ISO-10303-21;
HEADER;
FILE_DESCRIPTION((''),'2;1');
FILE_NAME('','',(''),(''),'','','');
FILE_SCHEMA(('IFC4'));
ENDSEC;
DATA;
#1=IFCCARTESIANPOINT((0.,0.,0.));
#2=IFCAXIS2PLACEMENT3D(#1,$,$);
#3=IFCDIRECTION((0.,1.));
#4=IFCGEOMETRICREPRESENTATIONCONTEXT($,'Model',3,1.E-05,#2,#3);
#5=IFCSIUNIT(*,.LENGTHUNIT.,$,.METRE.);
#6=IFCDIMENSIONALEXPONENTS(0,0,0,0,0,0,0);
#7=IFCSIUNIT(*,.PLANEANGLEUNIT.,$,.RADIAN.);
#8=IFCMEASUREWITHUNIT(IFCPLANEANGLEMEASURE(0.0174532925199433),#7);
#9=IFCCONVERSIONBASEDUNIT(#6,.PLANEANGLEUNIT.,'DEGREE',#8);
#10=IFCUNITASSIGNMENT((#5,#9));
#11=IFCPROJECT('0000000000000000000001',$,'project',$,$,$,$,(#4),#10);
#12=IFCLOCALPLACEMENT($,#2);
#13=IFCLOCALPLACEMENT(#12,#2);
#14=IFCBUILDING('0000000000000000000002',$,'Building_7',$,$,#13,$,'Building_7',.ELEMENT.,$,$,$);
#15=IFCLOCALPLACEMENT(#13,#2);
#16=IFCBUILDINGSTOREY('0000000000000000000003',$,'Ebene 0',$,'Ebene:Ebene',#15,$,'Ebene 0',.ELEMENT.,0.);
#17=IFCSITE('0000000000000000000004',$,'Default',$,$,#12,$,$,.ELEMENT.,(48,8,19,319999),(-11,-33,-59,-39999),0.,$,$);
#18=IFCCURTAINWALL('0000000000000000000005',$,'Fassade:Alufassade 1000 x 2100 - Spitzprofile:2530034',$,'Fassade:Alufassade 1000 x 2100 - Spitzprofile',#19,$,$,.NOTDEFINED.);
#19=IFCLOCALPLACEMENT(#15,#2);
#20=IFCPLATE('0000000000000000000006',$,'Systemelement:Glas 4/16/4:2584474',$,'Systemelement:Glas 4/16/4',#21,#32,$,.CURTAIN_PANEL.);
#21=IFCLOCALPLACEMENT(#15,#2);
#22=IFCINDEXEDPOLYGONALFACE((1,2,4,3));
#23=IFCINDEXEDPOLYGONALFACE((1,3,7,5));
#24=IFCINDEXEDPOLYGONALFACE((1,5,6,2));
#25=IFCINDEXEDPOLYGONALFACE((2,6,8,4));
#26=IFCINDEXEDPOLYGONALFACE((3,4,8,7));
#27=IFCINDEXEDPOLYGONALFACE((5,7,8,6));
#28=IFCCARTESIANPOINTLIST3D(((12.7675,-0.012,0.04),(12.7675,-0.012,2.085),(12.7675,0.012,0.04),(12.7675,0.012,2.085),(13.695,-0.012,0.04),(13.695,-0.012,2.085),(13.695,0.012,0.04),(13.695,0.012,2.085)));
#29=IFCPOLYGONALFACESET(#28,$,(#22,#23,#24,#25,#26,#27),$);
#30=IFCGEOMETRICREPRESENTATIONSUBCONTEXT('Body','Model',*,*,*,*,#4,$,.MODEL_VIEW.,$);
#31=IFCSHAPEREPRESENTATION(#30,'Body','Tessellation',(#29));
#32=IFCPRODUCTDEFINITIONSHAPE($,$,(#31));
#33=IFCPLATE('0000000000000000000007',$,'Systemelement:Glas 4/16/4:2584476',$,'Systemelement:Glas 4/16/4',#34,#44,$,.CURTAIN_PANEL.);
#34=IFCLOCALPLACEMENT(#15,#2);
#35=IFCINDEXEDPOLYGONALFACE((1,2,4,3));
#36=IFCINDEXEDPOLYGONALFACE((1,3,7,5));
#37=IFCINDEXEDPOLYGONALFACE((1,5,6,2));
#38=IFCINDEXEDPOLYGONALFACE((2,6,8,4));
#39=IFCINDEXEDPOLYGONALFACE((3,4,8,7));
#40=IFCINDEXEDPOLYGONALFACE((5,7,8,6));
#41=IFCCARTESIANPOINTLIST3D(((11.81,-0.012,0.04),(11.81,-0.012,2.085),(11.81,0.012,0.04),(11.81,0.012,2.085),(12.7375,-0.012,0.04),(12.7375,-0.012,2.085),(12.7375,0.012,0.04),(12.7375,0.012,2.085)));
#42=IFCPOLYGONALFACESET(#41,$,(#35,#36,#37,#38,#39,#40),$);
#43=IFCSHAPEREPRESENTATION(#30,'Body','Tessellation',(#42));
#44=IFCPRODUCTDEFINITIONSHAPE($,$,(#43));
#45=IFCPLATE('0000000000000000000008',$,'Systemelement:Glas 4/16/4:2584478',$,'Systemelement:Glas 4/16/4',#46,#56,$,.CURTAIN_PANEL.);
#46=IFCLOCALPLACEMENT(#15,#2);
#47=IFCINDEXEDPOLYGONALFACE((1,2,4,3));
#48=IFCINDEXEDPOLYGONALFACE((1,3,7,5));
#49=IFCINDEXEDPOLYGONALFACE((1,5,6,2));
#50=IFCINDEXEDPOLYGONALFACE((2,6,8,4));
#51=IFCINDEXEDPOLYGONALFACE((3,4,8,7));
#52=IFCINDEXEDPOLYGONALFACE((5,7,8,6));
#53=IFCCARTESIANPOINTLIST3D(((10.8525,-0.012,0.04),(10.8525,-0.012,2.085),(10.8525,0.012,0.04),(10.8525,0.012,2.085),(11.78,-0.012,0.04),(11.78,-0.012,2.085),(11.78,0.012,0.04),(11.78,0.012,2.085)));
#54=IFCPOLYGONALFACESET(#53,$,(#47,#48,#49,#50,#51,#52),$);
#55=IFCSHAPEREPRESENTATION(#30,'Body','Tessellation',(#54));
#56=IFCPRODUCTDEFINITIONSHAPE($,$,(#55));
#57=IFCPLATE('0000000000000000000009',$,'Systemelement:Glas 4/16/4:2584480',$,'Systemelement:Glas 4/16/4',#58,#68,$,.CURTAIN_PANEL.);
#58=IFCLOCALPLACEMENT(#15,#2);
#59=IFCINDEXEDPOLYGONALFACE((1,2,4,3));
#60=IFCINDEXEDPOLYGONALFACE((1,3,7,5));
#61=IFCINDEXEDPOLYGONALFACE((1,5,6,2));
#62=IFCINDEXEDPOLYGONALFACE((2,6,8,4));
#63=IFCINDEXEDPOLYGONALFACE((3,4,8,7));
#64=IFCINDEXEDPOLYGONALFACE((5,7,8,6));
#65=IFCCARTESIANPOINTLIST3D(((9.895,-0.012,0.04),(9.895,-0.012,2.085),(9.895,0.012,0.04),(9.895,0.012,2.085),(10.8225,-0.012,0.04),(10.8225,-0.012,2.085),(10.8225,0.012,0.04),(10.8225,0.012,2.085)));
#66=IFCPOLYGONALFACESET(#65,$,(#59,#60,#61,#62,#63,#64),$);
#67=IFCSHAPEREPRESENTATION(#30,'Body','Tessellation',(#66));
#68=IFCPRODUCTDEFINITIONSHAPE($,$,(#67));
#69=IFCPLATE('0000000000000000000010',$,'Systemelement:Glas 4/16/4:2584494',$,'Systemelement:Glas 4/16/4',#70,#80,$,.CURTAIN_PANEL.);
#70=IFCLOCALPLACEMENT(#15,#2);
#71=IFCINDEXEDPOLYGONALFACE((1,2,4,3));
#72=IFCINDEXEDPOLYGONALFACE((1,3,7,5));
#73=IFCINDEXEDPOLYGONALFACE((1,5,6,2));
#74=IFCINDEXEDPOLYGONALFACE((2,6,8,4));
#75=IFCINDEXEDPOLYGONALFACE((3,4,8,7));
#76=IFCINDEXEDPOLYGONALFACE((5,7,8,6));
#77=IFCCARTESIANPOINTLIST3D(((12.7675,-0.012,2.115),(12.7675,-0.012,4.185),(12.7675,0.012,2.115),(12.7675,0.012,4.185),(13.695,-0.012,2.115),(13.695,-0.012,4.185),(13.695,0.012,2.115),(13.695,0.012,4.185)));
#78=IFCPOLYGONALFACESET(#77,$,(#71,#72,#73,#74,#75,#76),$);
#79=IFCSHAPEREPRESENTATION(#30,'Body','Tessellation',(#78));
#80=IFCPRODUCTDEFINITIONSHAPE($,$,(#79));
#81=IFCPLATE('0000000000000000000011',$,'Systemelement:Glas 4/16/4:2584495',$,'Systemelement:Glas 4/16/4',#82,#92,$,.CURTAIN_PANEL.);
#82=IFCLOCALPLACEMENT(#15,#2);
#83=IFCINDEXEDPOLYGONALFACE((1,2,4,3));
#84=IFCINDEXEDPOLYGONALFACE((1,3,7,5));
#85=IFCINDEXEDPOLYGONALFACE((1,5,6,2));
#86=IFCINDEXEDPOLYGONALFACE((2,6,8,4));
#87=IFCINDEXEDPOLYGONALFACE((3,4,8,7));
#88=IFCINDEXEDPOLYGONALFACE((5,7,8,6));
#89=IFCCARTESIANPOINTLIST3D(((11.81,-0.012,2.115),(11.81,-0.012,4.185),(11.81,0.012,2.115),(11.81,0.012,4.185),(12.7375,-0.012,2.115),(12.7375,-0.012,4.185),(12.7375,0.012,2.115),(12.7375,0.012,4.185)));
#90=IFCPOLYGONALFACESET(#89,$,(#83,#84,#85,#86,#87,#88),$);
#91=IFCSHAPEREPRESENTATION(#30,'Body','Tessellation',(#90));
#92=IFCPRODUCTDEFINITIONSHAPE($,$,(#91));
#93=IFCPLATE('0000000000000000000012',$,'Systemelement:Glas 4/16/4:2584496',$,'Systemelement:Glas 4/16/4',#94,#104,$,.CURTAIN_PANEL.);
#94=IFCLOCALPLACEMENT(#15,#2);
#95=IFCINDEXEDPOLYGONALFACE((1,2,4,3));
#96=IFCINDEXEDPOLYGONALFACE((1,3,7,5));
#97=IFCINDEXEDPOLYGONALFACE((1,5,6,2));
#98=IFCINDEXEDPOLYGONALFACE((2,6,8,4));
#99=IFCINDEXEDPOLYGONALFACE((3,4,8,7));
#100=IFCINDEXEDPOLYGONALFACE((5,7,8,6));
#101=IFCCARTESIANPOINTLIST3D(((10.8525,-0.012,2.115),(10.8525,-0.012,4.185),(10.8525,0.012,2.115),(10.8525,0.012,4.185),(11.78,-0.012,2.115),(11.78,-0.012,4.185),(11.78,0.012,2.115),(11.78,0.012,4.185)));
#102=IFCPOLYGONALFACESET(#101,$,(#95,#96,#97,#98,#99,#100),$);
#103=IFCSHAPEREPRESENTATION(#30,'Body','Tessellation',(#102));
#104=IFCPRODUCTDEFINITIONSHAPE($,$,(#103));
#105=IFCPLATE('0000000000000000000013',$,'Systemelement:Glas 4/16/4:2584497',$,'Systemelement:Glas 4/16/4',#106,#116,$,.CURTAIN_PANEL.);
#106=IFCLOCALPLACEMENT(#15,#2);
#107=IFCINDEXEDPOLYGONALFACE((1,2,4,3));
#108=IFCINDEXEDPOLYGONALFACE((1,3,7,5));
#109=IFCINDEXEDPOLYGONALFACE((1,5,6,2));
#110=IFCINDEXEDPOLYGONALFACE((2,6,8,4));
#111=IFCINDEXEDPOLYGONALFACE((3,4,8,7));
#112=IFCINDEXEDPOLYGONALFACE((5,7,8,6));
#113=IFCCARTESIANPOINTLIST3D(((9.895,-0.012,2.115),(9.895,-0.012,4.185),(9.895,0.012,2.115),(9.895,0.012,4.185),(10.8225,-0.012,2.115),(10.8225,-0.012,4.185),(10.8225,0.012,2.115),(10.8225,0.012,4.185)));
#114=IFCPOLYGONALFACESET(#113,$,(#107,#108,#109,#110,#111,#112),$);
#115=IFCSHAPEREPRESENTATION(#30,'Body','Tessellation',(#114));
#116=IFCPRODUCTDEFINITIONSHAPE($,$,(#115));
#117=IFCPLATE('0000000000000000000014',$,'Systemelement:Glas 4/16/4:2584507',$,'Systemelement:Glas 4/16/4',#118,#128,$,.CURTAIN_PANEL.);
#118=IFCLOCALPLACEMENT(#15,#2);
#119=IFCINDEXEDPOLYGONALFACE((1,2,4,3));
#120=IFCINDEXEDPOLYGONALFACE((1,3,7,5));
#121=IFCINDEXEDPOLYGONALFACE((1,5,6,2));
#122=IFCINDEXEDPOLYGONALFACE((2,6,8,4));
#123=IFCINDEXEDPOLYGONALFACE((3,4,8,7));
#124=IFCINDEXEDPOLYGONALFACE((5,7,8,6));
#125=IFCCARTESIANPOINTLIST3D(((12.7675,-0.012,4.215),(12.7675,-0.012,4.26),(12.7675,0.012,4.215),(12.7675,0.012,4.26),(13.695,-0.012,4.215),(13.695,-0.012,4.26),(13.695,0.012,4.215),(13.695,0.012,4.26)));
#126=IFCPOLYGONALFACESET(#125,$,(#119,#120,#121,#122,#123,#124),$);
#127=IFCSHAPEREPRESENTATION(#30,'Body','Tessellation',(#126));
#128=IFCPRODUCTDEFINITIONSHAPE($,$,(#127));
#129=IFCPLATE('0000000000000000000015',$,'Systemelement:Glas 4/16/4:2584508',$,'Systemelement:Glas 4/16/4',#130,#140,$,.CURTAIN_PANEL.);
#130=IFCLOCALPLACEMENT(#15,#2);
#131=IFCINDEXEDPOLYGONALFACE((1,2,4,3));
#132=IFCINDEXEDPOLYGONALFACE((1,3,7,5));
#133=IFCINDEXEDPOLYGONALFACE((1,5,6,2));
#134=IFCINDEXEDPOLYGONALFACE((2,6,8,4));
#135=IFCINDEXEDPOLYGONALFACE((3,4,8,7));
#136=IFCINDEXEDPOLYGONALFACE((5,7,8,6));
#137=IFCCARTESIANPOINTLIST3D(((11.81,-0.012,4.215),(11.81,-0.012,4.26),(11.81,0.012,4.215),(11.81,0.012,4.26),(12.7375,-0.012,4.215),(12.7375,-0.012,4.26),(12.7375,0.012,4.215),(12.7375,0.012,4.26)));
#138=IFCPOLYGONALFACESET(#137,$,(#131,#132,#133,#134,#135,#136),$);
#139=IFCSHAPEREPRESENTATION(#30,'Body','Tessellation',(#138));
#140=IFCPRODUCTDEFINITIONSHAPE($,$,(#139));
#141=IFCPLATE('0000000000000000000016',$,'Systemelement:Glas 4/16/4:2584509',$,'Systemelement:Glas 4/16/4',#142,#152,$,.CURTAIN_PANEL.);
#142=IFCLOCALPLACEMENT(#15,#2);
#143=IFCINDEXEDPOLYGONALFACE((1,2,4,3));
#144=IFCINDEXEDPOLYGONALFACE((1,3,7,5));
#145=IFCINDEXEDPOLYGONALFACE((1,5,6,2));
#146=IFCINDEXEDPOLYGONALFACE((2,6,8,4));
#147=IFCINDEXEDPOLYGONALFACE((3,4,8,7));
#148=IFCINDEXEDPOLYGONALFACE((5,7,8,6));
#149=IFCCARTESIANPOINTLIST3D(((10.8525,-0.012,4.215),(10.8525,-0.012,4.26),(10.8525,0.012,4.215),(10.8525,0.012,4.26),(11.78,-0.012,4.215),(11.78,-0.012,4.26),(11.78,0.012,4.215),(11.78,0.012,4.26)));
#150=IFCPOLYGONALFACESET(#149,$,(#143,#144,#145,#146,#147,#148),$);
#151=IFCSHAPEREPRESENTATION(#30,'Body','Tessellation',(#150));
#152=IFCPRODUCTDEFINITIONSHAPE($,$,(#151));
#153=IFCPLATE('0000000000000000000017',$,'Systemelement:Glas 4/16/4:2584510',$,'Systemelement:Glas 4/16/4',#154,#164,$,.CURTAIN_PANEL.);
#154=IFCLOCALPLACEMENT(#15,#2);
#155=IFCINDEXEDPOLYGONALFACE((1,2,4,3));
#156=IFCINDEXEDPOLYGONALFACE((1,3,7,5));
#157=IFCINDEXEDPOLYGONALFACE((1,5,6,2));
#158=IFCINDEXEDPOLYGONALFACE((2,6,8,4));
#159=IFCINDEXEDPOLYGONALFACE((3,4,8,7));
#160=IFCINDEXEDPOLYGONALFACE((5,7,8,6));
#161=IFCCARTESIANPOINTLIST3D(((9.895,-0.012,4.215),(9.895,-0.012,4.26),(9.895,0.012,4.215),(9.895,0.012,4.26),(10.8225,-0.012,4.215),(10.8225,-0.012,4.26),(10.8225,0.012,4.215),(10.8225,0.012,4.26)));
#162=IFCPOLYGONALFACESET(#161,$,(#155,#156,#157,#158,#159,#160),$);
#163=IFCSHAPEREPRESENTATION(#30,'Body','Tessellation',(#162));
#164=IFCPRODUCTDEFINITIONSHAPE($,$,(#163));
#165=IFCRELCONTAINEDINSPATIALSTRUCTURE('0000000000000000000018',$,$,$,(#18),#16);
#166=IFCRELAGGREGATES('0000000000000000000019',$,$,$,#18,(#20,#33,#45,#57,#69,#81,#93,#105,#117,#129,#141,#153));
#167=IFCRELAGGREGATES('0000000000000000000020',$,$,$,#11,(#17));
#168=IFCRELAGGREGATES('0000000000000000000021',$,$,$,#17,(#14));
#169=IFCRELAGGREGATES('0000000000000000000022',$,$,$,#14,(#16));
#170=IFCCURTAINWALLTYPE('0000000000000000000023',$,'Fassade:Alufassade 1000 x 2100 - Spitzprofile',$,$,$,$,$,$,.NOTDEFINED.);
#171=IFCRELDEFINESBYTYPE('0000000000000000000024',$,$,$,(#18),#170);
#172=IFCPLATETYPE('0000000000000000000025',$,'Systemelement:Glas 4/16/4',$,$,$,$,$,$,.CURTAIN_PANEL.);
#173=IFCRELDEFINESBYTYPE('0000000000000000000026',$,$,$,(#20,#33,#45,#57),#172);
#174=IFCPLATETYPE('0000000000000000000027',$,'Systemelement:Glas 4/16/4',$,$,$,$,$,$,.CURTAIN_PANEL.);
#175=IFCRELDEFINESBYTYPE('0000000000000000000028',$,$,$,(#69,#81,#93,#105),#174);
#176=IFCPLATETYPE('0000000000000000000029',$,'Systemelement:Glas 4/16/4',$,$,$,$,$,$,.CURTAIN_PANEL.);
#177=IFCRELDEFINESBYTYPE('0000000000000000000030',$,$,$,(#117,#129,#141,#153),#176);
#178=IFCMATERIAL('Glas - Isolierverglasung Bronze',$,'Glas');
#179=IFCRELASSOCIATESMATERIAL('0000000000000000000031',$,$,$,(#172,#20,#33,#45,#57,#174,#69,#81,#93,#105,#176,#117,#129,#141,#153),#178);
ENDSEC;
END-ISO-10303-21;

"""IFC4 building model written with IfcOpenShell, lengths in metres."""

from ifc_helpers import new_model, entity, si_unit, converted_unit, direction, frame, origin, place, context, subcontext, project, spatial, indexed_curve, outline, extrude, source, transform, mapped, material, type_object, type_shapes, element, aggregate, save


model = new_model("IFC4")

# Units and contexts
model_context = context("Model", 3, precision=1e-05, world=origin(), true_north=direction((0.0, 1.0)))
body_context = subcontext(model_context, "Body", "Model", "MODEL_VIEW")
ifc_project = project(units=[si_unit("LENGTHUNIT", "METRE"), converted_unit("PLANEANGLEUNIT", "DEGREE", entity("IfcPlaneAngleMeasure", 0.0174532925199433), si_unit("PLANEANGLEUNIT", "RADIAN"), dimensions=[0, 0, 0, 0, 0, 0, 0])], contexts=[model_context])

# Site, building, storey
site_placement = place(None, origin())
site = spatial("IfcSite", under=ifc_project, at=site_placement, Name="Default", CompositionType="ELEMENT", RefLatitude=(48, 8, 19, 319999), RefLongitude=(-11, -33, -59, -39999), RefElevation=0.0)
building_placement = place(site_placement, origin())
building = spatial("IfcBuilding", under=site, at=building_placement, Name="Building_7", LongName="Building_7", CompositionType="ELEMENT")
storey_placement = place(building_placement, origin())
storey = spatial("IfcBuildingStorey", under=building, at=storey_placement, Name="Ebene 0", ObjectType="Ebene:Ebene", LongName="Ebene 0", CompositionType="ELEMENT", Elevation=0.0)

# Curtain wall, plates
curtain_wall_type = type_object("IfcCurtainWallType", Name="Fassade:Alufassade 1000 x 2100 - Spitzprofile", PredefinedType="NOTDEFINED")
curtain_wall_placement = place(storey_placement, origin())
curtain_wall = element("IfcCurtainWall", 1, at=curtain_wall_placement, inside=storey, type_object=curtain_wall_type, Name="Fassade:Alufassade 1000 x 2100 - Spitzprofile:2530034", ObjectType="Fassade:Alufassade 1000 x 2100 - Spitzprofile", PredefinedType="NOTDEFINED")
ifc_material_1 = material(Name="Glas - Isolierverglasung Bronze", Category="Glas")
plate_type_1 = type_object("IfcPlateType", Name="Systemelement:Glas 4/16/4", PredefinedType="CURTAIN_PANEL", material=ifc_material_1)
shared_shape_1 = source(origin(), body_context, "Body", "SweptSolid", [
    extrude(outline(indexed_curve([(-0.012, -0.4637), (0.012, -0.4637), (0.012, 0.4637), (-0.012, 0.4637), (-0.012, -0.4637)], self_intersect=False)), frame((0.0, 0.0, 0.0), z_axis=(0.0, 0.0, 1.0), x_axis=(0.0, 1.0, 0.0)), (0.0, 0.0, 1.0), 2.045),
])
type_shapes(plate_type_1, [shared_shape_1])
plate_1_placement = place(curtain_wall_placement, frame((13.2312, 0.0, 0.04), z_axis=(0.0, 0.0, 1.0), x_axis=(-1.0, 0.0, 0.0)))
plate_1 = element("IfcPlate", 2, at=plate_1_placement, type_object=plate_type_1, material=ifc_material_1, Name="Systemelement:Glas 4/16/4:2584474", ObjectType="Systemelement:Glas 4/16/4", PredefinedType="CURTAIN_PANEL", context=body_context, shape_type="MappedRepresentation", body=[
    mapped(shared_shape_1, transform((0.0, 0.0, 0.0), scale=1.0)),
])
plate_2_placement = place(curtain_wall_placement, frame((12.2737, 0.0, 0.04), z_axis=(0.0, 0.0, 1.0), x_axis=(-1.0, 0.0, 0.0)))
plate_2 = element("IfcPlate", 3, at=plate_2_placement, type_object=plate_type_1, material=ifc_material_1, Name="Systemelement:Glas 4/16/4:2584476", ObjectType="Systemelement:Glas 4/16/4", PredefinedType="CURTAIN_PANEL", context=body_context, shape_type="MappedRepresentation", body=[
    mapped(shared_shape_1, transform((0.0, 0.0, 0.0), scale=1.0)),
])
plate_3_placement = place(curtain_wall_placement, frame((11.3163, 0.0, 0.04), z_axis=(0.0, 0.0, 1.0), x_axis=(-1.0, 0.0, 0.0)))
plate_3 = element("IfcPlate", 4, at=plate_3_placement, type_object=plate_type_1, material=ifc_material_1, Name="Systemelement:Glas 4/16/4:2584478", ObjectType="Systemelement:Glas 4/16/4", PredefinedType="CURTAIN_PANEL", context=body_context, shape_type="MappedRepresentation", body=[
    mapped(shared_shape_1, transform((0.0, 0.0, 0.0), scale=1.0)),
])
plate_4_placement = place(curtain_wall_placement, frame((10.3588, 0.0, 0.04), z_axis=(0.0, 0.0, 1.0), x_axis=(-1.0, 0.0, 0.0)))
plate_4 = element("IfcPlate", 5, at=plate_4_placement, type_object=plate_type_1, material=ifc_material_1, Name="Systemelement:Glas 4/16/4:2584480", ObjectType="Systemelement:Glas 4/16/4", PredefinedType="CURTAIN_PANEL", context=body_context, shape_type="MappedRepresentation", body=[
    mapped(shared_shape_1, transform((0.0, 0.0, 0.0), scale=1.0)),
])
plate_type_2 = type_object("IfcPlateType", Name="Systemelement:Glas 4/16/4", PredefinedType="CURTAIN_PANEL", material=ifc_material_1)
shared_shape_2 = source(origin(), body_context, "Body", "SweptSolid", [
    extrude(outline(indexed_curve([(-0.012, -0.4637), (0.012, -0.4637), (0.012, 0.4637), (-0.012, 0.4637), (-0.012, -0.4637)], self_intersect=False)), frame((0.0, 0.0, 0.0), z_axis=(0.0, 0.0, 1.0), x_axis=(0.0, 1.0, 0.0)), (0.0, 0.0, 1.0), 2.07),
])
type_shapes(plate_type_2, [shared_shape_2])
plate_5_placement = place(curtain_wall_placement, frame((13.2312, 0.0, 2.115), z_axis=(0.0, 0.0, 1.0), x_axis=(-1.0, 0.0, 0.0)))
plate_5 = element("IfcPlate", 6, at=plate_5_placement, type_object=plate_type_2, material=ifc_material_1, Name="Systemelement:Glas 4/16/4:2584494", ObjectType="Systemelement:Glas 4/16/4", PredefinedType="CURTAIN_PANEL", context=body_context, shape_type="MappedRepresentation", body=[
    mapped(shared_shape_2, transform((0.0, 0.0, 0.0), scale=1.0)),
])
plate_6_placement = place(curtain_wall_placement, frame((12.2737, 0.0, 2.115), z_axis=(0.0, 0.0, 1.0), x_axis=(-1.0, 0.0, 0.0)))
plate_6 = element("IfcPlate", 7, at=plate_6_placement, type_object=plate_type_2, material=ifc_material_1, Name="Systemelement:Glas 4/16/4:2584495", ObjectType="Systemelement:Glas 4/16/4", PredefinedType="CURTAIN_PANEL", context=body_context, shape_type="MappedRepresentation", body=[
    mapped(shared_shape_2, transform((0.0, 0.0, 0.0), scale=1.0)),
])
plate_7_placement = place(curtain_wall_placement, frame((11.3163, 0.0, 2.115), z_axis=(0.0, 0.0, 1.0), x_axis=(-1.0, 0.0, 0.0)))
plate_7 = element("IfcPlate", 8, at=plate_7_placement, type_object=plate_type_2, material=ifc_material_1, Name="Systemelement:Glas 4/16/4:2584496", ObjectType="Systemelement:Glas 4/16/4", PredefinedType="CURTAIN_PANEL", context=body_context, shape_type="MappedRepresentation", body=[
    mapped(shared_shape_2, transform((0.0, 0.0, 0.0), scale=1.0)),
])
plate_8_placement = place(curtain_wall_placement, frame((10.3588, 0.0, 2.115), z_axis=(0.0, 0.0, 1.0), x_axis=(-1.0, 0.0, 0.0)))
plate_8 = element("IfcPlate", 9, at=plate_8_placement, type_object=plate_type_2, material=ifc_material_1, Name="Systemelement:Glas 4/16/4:2584497", ObjectType="Systemelement:Glas 4/16/4", PredefinedType="CURTAIN_PANEL", context=body_context, shape_type="MappedRepresentation", body=[
    mapped(shared_shape_2, transform((0.0, 0.0, 0.0), scale=1.0)),
])
plate_type_3 = type_object("IfcPlateType", Name="Systemelement:Glas 4/16/4", PredefinedType="CURTAIN_PANEL", material=ifc_material_1)
shared_shape_3 = source(origin(), body_context, "Body", "SweptSolid", [
    extrude(outline(indexed_curve([(-0.012, -0.4637), (0.012, -0.4637), (0.012, 0.4637), (-0.012, 0.4637), (-0.012, -0.4637)], self_intersect=False)), frame((0.0, 0.0, 0.0), z_axis=(0.0, 0.0, 1.0), x_axis=(0.0, 1.0, 0.0)), (0.0, 0.0, 1.0), 0.045),
])
type_shapes(plate_type_3, [shared_shape_3])
plate_9_placement = place(curtain_wall_placement, frame((13.2312, 0.0, 4.215), z_axis=(0.0, 0.0, 1.0), x_axis=(-1.0, 0.0, 0.0)))
plate_9 = element("IfcPlate", 10, at=plate_9_placement, type_object=plate_type_3, material=ifc_material_1, Name="Systemelement:Glas 4/16/4:2584507", ObjectType="Systemelement:Glas 4/16/4", PredefinedType="CURTAIN_PANEL", context=body_context, shape_type="MappedRepresentation", body=[
    mapped(shared_shape_3, transform((0.0, 0.0, 0.0), scale=1.0)),
])
plate_10_placement = place(curtain_wall_placement, frame((12.2737, 0.0, 4.215), z_axis=(0.0, 0.0, 1.0), x_axis=(-1.0, 0.0, 0.0)))
plate_10 = element("IfcPlate", 11, at=plate_10_placement, type_object=plate_type_3, material=ifc_material_1, Name="Systemelement:Glas 4/16/4:2584508", ObjectType="Systemelement:Glas 4/16/4", PredefinedType="CURTAIN_PANEL", context=body_context, shape_type="MappedRepresentation", body=[
    mapped(shared_shape_3, transform((0.0, 0.0, 0.0), scale=1.0)),
])
plate_11_placement = place(curtain_wall_placement, frame((11.3163, 0.0, 4.215), z_axis=(0.0, 0.0, 1.0), x_axis=(-1.0, 0.0, 0.0)))
plate_11 = element("IfcPlate", 12, at=plate_11_placement, type_object=plate_type_3, material=ifc_material_1, Name="Systemelement:Glas 4/16/4:2584509", ObjectType="Systemelement:Glas 4/16/4", PredefinedType="CURTAIN_PANEL", context=body_context, shape_type="MappedRepresentation", body=[
    mapped(shared_shape_3, transform((0.0, 0.0, 0.0), scale=1.0)),
])
plate_12_placement = place(curtain_wall_placement, frame((10.3588, 0.0, 4.215), z_axis=(0.0, 0.0, 1.0), x_axis=(-1.0, 0.0, 0.0)))
plate_12 = element("IfcPlate", 13, at=plate_12_placement, type_object=plate_type_3, material=ifc_material_1, Name="Systemelement:Glas 4/16/4:2584510", ObjectType="Systemelement:Glas 4/16/4", PredefinedType="CURTAIN_PANEL", context=body_context, shape_type="MappedRepresentation", body=[
    mapped(shared_shape_3, transform((0.0, 0.0, 0.0), scale=1.0)),
])
aggregate(curtain_wall, [plate_1, plate_2, plate_3, plate_4, plate_5, plate_6, plate_7, plate_8, plate_9, plate_10, plate_11, plate_12])

save(model, "model.ifc")
